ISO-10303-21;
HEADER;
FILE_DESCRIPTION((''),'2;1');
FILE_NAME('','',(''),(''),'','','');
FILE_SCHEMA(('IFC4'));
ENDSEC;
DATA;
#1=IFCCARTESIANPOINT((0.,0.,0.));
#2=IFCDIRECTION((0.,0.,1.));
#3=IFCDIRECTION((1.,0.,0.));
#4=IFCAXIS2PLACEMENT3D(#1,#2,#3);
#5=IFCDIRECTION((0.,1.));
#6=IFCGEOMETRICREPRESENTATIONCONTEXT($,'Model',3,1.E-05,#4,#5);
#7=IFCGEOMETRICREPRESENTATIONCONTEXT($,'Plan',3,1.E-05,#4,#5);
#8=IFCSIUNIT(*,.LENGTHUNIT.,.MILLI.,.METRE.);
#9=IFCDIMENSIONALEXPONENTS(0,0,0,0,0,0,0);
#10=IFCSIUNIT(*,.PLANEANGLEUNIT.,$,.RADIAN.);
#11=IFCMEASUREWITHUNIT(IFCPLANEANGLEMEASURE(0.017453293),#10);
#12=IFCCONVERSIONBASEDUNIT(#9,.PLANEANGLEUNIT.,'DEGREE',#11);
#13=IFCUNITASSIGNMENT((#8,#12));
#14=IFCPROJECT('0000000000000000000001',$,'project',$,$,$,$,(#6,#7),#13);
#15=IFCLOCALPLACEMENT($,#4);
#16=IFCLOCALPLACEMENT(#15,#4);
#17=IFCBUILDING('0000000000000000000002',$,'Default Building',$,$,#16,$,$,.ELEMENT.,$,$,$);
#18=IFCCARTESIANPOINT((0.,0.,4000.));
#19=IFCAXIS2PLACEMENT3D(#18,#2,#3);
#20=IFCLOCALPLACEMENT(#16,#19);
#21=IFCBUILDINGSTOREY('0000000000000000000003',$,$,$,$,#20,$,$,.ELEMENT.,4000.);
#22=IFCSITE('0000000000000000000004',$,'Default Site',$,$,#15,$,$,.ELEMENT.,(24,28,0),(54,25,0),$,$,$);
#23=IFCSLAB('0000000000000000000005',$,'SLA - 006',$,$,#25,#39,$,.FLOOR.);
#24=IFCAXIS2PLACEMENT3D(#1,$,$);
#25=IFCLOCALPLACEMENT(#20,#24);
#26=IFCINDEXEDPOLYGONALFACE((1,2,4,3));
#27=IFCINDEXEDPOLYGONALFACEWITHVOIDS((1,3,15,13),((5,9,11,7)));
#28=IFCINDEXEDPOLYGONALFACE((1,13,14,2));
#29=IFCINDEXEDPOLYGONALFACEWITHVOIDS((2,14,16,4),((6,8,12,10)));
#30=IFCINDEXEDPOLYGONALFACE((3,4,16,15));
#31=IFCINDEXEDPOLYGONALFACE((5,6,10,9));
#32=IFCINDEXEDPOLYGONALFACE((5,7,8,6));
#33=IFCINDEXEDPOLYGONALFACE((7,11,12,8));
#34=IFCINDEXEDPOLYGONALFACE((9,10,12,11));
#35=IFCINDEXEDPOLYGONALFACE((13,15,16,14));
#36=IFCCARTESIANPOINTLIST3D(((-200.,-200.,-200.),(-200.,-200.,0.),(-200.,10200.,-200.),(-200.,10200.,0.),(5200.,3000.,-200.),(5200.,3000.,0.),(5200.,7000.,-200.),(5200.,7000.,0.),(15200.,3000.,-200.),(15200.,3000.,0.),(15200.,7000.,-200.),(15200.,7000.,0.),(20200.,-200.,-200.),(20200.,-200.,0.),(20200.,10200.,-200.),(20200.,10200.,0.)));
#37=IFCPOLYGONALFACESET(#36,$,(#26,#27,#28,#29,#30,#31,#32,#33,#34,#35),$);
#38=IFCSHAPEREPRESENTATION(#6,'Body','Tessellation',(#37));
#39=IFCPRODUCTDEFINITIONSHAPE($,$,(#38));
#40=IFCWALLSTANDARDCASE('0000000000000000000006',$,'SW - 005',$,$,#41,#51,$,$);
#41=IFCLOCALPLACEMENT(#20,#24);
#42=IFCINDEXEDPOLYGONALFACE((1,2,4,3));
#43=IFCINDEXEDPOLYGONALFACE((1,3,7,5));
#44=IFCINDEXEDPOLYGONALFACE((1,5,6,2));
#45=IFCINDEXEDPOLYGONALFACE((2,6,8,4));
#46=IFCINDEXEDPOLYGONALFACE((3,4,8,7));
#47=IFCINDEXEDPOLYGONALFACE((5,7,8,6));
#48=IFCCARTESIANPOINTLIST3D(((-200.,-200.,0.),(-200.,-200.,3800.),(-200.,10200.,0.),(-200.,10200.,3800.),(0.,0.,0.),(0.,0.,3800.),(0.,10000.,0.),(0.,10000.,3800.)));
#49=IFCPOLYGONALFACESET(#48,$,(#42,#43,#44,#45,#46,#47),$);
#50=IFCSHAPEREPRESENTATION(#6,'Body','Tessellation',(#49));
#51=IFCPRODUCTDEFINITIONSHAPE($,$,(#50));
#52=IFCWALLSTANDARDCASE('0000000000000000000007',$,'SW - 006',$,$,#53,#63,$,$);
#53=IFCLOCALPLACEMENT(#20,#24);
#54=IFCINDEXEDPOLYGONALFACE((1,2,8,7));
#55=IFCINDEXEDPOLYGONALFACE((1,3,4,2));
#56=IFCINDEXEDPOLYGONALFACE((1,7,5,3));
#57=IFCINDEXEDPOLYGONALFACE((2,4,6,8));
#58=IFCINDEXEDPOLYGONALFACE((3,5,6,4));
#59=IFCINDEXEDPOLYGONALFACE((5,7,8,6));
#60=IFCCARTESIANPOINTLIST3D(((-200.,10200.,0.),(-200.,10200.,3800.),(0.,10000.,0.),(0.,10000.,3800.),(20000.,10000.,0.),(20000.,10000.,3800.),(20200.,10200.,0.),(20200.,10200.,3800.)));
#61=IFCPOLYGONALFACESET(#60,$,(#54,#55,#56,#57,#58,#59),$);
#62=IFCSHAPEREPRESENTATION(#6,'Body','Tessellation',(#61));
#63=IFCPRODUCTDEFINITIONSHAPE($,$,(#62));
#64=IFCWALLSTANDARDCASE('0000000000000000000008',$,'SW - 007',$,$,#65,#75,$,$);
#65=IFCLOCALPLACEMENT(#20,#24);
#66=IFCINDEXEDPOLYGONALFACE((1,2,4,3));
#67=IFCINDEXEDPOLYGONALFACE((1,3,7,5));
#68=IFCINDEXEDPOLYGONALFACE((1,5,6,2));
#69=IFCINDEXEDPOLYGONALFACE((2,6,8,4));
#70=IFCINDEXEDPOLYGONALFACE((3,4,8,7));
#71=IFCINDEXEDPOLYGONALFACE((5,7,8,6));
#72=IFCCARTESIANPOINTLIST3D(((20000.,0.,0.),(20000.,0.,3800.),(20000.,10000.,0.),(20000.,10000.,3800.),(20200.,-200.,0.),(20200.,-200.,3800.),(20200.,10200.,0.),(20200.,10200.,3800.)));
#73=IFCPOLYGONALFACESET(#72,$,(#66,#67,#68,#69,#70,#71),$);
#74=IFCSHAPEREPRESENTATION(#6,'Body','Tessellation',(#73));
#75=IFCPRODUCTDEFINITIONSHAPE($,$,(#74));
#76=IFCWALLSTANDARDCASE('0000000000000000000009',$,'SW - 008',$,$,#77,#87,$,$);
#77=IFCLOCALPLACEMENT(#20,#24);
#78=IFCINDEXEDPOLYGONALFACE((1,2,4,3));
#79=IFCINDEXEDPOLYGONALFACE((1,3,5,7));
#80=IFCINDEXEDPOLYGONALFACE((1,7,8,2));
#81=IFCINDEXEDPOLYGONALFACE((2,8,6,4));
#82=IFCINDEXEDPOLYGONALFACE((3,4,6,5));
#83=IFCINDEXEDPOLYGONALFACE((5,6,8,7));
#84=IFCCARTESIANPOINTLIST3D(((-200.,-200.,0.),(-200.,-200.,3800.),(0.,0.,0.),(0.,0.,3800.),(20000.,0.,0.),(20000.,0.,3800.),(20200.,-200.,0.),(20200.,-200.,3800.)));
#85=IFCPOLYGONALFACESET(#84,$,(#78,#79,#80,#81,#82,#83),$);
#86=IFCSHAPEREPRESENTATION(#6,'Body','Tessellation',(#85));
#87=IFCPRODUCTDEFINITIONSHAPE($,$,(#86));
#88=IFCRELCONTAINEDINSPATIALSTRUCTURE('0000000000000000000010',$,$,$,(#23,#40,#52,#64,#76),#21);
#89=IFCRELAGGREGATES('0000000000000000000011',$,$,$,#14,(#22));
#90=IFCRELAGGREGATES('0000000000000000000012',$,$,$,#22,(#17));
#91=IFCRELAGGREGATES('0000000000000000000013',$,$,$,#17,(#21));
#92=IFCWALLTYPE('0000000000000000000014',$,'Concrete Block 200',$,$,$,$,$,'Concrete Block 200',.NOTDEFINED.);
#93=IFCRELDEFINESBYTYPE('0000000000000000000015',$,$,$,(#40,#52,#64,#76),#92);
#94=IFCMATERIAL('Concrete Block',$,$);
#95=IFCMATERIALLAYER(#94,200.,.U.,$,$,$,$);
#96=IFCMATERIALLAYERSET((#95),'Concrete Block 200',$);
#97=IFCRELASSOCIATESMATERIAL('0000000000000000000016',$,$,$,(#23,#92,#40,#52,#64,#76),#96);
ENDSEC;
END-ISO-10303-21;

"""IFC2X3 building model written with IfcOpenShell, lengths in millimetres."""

from ifc_helpers import new_model, entity, si_unit, converted_unit, direction, frame, origin_with_axes, place, context, project, spatial, polyline, outline, extrude, material, layer, layer_set, layer_usage, type_object, element, save


model = new_model("IFC2X3")

# Units and contexts
model_context = context("Model", 3, precision=1e-05, world=origin_with_axes(), true_north=direction((0.0, 1.0)))
plan_context = context("Plan", 3, precision=1e-05, world=origin_with_axes(), true_north=direction((0.0, 1.0)))
ifc_project = project(units=[si_unit("LENGTHUNIT", "METRE", prefix="MILLI"), converted_unit("PLANEANGLEUNIT", "DEGREE", entity("IfcPlaneAngleMeasure", 0.017453293), si_unit("PLANEANGLEUNIT", "RADIAN"), dimensions=[0, 0, 0, 0, 0, 0, 0])], contexts=[model_context, plan_context])

# Site, building, storey
site_placement = place(None, origin_with_axes())
site = spatial("IfcSite", under=ifc_project, at=site_placement, Name="Default Site", CompositionType="ELEMENT", RefLatitude=(24, 28, 0), RefLongitude=(54, 25, 0))
building_placement = place(site_placement, origin_with_axes())
building = spatial("IfcBuilding", under=site, at=building_placement, Name="Default Building", CompositionType="ELEMENT")
storey_placement = place(building_placement, frame((0.0, 0.0, 4000.0), z_axis=(0.0, 0.0, 1.0), x_axis=(1.0, 0.0, 0.0)))
storey = spatial("IfcBuildingStorey", under=building, at=storey_placement, CompositionType="ELEMENT", Elevation=4000.0)

# Slab, opening
ifc_material = material(Name="Concrete Block")
ifc_layer = layer(ifc_material, 200.0, ventilated="UNKNOWN")
ifc_layer_set = layer_set([ifc_layer], Name="Concrete Block 200")
ifc_layer_usage_1 = layer_usage(ifc_layer_set, "AXIS3", "NEGATIVE", 200.0)
slab_placement = place(storey_placement, frame((-200.0, -200.0, -200.0), z_axis=(0.0, 0.0, 1.0), x_axis=(1.0, 0.0, 0.0)))
slab = element("IfcSlab", 1, at=slab_placement, inside=storey, material=ifc_layer_usage_1, Name="SLA - 006", PredefinedType="FLOOR", context=model_context, shape_type="SweptSolid", body=[
    extrude(outline(polyline([(0.0, 0.0), (20400.0, 0.0), (20400.0, 10400.0), (0.0, 10400.0), (0.0, 0.0)])), origin_with_axes(), (0.0, 0.0, 1.0), 200.0),
])
opening_placement = place(slab_placement, origin_with_axes())
element("IfcOpeningElement", 2, at=opening_placement, cuts=slab, context=model_context, shape_type="SweptSolid", body=[
    extrude(outline(polyline([(15400.0, 3200.0), (5400.0, 3200.0), (5400.0, 7200.0), (15400.0, 7200.0), (15400.0, 3200.0)])), origin_with_axes(), (0.0, 0.0, 1.0), 200.0),
])

# Walls
ifc_layer_usage_2 = layer_usage(ifc_layer_set, "AXIS2", "POSITIVE", 0.0)
wall_type = type_object("IfcWallType", Name="Concrete Block 200", ElementType="Concrete Block 200", PredefinedType="NOTDEFINED", material=ifc_layer_set)
wall_1_placement = place(storey_placement, frame((0.0, 0.0, 0.0), z_axis=(0.0, 0.0, 1.0), x_axis=(0.0, 1.0, 0.0)))
element("IfcWallStandardCase", 3, at=wall_1_placement, inside=storey, type_object=wall_type, material=ifc_layer_usage_2, Name="SW - 005", context=model_context, shape_type="SweptSolid", body=[
    extrude(outline(polyline([(0.0, 0.0), (10000.0, 0.0), (10200.0, 200.0), (-200.0, 200.0), (0.0, 0.0)])), origin_with_axes(), (0.0, 0.0, 1.0), 3800.0),
])
ifc_layer_usage_3 = layer_usage(ifc_layer_set, "AXIS2", "POSITIVE", 0.0)
wall_2_placement = place(storey_placement, frame((0.0, 10000.0, 0.0), z_axis=(0.0, 0.0, 1.0), x_axis=(1.0, 0.0, 0.0)))
element("IfcWallStandardCase", 4, at=wall_2_placement, inside=storey, type_object=wall_type, material=ifc_layer_usage_3, Name="SW - 006", context=model_context, shape_type="SweptSolid", body=[
    extrude(outline(polyline([(0.0, 0.0), (20000.0, 0.0), (20200.0, 200.0), (-200.0, 200.0), (0.0, 0.0)])), origin_with_axes(), (0.0, 0.0, 1.0), 3800.0),
])
ifc_layer_usage_4 = layer_usage(ifc_layer_set, "AXIS2", "POSITIVE", 0.0)
wall_3_placement = place(storey_placement, frame((20000.0, 10000.0, 0.0), z_axis=(0.0, 0.0, 1.0), x_axis=(0.0, -1.0, 0.0)))
element("IfcWallStandardCase", 5, at=wall_3_placement, inside=storey, type_object=wall_type, material=ifc_layer_usage_4, Name="SW - 007", context=model_context, shape_type="SweptSolid", body=[
    extrude(outline(polyline([(0.0, 0.0), (10000.0, 0.0), (10200.0, 200.0), (-200.0, 200.0), (0.0, 0.0)])), origin_with_axes(), (0.0, 0.0, 1.0), 3800.0),
])
ifc_layer_usage_5 = layer_usage(ifc_layer_set, "AXIS2", "POSITIVE", 0.0)
wall_4_placement = place(storey_placement, frame((20000.0, 0.0, 0.0), z_axis=(0.0, 0.0, 1.0), x_axis=(-1.0, 0.0, 0.0)))
element("IfcWallStandardCase", 6, at=wall_4_placement, inside=storey, type_object=wall_type, material=ifc_layer_usage_5, Name="SW - 008", context=model_context, shape_type="SweptSolid", body=[
    extrude(outline(polyline([(0.0, 0.0), (20000.0, 0.0), (20200.0, 200.0), (-200.0, 200.0), (0.0, 0.0)])), origin_with_axes(), (0.0, 0.0, 1.0), 3800.0),
])

save(model, "model.ifc")
